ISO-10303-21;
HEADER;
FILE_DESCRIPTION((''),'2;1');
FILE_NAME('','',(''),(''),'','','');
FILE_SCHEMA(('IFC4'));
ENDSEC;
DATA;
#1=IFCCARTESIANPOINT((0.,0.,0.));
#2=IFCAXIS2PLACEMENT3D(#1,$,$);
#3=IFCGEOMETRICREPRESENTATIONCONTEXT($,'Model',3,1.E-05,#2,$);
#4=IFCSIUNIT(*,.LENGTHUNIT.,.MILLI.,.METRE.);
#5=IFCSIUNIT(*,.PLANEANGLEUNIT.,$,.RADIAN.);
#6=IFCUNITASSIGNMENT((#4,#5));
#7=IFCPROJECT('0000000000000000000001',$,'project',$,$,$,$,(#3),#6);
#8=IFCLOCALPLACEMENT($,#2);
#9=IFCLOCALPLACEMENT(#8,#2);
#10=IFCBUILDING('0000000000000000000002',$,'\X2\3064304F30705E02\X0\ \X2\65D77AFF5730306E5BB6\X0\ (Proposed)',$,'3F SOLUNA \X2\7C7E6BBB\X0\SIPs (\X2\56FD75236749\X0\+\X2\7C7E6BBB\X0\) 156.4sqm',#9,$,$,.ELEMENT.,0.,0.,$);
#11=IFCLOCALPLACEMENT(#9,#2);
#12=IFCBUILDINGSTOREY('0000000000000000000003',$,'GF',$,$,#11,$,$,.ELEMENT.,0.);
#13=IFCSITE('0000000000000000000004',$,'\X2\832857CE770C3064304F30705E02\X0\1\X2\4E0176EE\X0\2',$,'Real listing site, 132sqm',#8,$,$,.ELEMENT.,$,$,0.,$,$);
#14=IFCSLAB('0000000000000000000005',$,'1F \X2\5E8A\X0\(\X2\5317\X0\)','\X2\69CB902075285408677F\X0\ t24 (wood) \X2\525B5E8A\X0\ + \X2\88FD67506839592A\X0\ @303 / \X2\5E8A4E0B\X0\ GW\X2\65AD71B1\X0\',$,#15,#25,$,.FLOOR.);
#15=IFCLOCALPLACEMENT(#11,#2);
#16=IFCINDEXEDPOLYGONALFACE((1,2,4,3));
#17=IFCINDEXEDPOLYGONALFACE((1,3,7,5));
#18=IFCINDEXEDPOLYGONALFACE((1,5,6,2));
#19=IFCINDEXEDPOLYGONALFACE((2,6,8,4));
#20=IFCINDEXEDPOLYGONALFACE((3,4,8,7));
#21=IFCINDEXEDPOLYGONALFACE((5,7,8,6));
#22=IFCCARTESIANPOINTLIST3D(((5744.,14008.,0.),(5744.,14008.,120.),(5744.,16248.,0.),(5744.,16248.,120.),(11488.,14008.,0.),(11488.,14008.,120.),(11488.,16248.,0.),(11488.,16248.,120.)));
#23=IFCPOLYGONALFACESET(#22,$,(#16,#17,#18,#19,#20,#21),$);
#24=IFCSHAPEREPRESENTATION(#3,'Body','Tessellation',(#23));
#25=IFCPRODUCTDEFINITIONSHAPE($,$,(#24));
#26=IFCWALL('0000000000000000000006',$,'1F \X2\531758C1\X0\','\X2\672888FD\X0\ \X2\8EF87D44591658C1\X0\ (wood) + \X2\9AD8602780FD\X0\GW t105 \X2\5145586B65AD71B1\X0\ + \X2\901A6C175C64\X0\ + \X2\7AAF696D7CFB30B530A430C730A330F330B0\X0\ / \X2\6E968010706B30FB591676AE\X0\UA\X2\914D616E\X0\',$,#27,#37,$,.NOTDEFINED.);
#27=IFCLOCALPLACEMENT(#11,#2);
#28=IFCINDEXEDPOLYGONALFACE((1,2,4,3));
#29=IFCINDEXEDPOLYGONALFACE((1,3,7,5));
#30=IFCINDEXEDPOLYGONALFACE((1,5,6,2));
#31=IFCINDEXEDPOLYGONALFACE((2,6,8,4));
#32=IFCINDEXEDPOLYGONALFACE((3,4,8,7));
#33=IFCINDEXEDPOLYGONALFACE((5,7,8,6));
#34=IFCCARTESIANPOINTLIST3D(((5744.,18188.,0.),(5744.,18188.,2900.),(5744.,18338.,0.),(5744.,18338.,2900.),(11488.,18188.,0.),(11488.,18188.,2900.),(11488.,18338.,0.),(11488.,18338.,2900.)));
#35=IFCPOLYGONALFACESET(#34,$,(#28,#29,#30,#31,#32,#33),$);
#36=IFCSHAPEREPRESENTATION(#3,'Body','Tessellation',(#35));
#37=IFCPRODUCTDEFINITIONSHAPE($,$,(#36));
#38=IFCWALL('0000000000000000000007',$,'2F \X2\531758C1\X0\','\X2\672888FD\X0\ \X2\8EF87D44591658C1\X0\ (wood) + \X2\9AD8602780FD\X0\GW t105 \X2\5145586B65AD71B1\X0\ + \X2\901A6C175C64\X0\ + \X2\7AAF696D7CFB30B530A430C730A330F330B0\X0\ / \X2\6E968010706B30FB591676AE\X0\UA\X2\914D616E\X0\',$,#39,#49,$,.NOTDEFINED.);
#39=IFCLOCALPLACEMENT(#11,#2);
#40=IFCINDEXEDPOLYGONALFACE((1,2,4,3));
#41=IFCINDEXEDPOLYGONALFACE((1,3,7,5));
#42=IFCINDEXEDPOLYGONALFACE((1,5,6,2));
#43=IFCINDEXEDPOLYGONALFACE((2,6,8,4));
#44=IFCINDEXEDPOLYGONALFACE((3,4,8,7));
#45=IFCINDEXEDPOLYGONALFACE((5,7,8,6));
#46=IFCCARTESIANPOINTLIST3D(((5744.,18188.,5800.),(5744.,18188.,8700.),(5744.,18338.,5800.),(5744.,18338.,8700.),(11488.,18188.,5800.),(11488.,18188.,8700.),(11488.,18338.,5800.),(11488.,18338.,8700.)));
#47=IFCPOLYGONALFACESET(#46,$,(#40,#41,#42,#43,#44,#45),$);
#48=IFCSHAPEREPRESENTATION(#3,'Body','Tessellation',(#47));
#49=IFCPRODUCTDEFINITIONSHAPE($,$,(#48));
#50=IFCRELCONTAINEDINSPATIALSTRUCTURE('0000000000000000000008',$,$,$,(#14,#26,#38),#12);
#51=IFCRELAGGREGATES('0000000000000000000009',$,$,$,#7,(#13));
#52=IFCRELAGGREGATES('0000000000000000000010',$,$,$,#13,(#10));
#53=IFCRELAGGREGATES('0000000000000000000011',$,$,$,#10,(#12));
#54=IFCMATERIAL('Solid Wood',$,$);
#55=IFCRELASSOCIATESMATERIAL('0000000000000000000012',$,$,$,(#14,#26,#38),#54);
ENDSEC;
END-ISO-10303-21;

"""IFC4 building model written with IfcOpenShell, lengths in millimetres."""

from ifc_helpers import new_model, si_unit, frame, frame_2d, origin, place, context, project, spatial, rectangle, extrude, material, element, save


model = new_model("IFC4")

# Units and contexts
model_context = context("Model", 3, precision=1e-05, world=origin())
ifc_project = project(units=[si_unit("LENGTHUNIT", "METRE", prefix="MILLI"), si_unit("PLANEANGLEUNIT", "RADIAN")], contexts=[model_context])

# Site, building, storey
site_placement = place(None, origin())
site = spatial("IfcSite", under=ifc_project, at=site_placement, Name="茨城県つくば市1丁目2", ObjectType="Real listing site, 132sqm", CompositionType="ELEMENT", RefElevation=0.0)
building_placement = place(site_placement, origin())
building = spatial("IfcBuilding", under=site, at=building_placement, Name="つくば市 旗竿地の家 (Proposed)", ObjectType="3F SOLUNA 籾殻SIPs (国産杉+籾殻) 156.4sqm", CompositionType="ELEMENT", ElevationOfRefHeight=0.0, ElevationOfTerrain=0.0)
storey_placement = place(building_placement, origin())
storey = spatial("IfcBuildingStorey", under=building, at=storey_placement, Name="GF", CompositionType="ELEMENT", Elevation=0.0)

# Slab
ifc_material_1 = material(Name="Solid Wood")
slab_1_placement = place(storey_placement, frame((2872.0, 7004.0, 0.0)))
element("IfcSlab", 1, at=slab_1_placement, inside=storey, material=ifc_material_1, Name="1F 床(北)", Description="構造用合板 t24 (wood) 剛床 + 製材根太 @303 / 床下 GW断熱", PredefinedType="FLOOR", context=model_context, shape_type="SweptSolid", body=[
    extrude(rectangle(XDim=5744.0, YDim=2240.0, at=frame_2d((2872.0, 1120.0))), frame((2872.0, 7004.0, 0.0)), (0.0, 0.0, 1.0), 120.0),
])

# Wall
wall_1_placement = place(storey_placement, frame((2872.0, 9094.0, 0.0)))
element("IfcWall", 2, at=wall_1_placement, inside=storey, material=ifc_material_1, Name="1F 北壁", Description="木製 軸組外壁 (wood) + 高性能GW t105 充填断熱 + 通気層 + 窯業系サイディング / 準耐火・外皮UA配慮", PredefinedType="NOTDEFINED", context=model_context, shape_type="SweptSolid", body=[
    extrude(rectangle(XDim=5744.0, YDim=150.0, at=frame_2d((2872.0, 75.0))), frame((2872.0, 9094.0, 0.0)), (0.0, 0.0, 1.0), 2900.0),
])

# Wall
wall_2_placement = place(storey_placement, frame((2872.0, 9094.0, 2900.0)))
element("IfcWall", 3, at=wall_2_placement, inside=storey, material=ifc_material_1, Name="2F 北壁", Description="木製 軸組外壁 (wood) + 高性能GW t105 充填断熱 + 通気層 + 窯業系サイディング / 準耐火・外皮UA配慮", PredefinedType="NOTDEFINED", context=model_context, shape_type="SweptSolid", body=[
    extrude(rectangle(XDim=5744.0, YDim=150.0, at=frame_2d((2872.0, 75.0))), frame((2872.0, 9094.0, 2900.0)), (0.0, 0.0, 1.0), 2900.0),
])

save(model, "model.ifc")
